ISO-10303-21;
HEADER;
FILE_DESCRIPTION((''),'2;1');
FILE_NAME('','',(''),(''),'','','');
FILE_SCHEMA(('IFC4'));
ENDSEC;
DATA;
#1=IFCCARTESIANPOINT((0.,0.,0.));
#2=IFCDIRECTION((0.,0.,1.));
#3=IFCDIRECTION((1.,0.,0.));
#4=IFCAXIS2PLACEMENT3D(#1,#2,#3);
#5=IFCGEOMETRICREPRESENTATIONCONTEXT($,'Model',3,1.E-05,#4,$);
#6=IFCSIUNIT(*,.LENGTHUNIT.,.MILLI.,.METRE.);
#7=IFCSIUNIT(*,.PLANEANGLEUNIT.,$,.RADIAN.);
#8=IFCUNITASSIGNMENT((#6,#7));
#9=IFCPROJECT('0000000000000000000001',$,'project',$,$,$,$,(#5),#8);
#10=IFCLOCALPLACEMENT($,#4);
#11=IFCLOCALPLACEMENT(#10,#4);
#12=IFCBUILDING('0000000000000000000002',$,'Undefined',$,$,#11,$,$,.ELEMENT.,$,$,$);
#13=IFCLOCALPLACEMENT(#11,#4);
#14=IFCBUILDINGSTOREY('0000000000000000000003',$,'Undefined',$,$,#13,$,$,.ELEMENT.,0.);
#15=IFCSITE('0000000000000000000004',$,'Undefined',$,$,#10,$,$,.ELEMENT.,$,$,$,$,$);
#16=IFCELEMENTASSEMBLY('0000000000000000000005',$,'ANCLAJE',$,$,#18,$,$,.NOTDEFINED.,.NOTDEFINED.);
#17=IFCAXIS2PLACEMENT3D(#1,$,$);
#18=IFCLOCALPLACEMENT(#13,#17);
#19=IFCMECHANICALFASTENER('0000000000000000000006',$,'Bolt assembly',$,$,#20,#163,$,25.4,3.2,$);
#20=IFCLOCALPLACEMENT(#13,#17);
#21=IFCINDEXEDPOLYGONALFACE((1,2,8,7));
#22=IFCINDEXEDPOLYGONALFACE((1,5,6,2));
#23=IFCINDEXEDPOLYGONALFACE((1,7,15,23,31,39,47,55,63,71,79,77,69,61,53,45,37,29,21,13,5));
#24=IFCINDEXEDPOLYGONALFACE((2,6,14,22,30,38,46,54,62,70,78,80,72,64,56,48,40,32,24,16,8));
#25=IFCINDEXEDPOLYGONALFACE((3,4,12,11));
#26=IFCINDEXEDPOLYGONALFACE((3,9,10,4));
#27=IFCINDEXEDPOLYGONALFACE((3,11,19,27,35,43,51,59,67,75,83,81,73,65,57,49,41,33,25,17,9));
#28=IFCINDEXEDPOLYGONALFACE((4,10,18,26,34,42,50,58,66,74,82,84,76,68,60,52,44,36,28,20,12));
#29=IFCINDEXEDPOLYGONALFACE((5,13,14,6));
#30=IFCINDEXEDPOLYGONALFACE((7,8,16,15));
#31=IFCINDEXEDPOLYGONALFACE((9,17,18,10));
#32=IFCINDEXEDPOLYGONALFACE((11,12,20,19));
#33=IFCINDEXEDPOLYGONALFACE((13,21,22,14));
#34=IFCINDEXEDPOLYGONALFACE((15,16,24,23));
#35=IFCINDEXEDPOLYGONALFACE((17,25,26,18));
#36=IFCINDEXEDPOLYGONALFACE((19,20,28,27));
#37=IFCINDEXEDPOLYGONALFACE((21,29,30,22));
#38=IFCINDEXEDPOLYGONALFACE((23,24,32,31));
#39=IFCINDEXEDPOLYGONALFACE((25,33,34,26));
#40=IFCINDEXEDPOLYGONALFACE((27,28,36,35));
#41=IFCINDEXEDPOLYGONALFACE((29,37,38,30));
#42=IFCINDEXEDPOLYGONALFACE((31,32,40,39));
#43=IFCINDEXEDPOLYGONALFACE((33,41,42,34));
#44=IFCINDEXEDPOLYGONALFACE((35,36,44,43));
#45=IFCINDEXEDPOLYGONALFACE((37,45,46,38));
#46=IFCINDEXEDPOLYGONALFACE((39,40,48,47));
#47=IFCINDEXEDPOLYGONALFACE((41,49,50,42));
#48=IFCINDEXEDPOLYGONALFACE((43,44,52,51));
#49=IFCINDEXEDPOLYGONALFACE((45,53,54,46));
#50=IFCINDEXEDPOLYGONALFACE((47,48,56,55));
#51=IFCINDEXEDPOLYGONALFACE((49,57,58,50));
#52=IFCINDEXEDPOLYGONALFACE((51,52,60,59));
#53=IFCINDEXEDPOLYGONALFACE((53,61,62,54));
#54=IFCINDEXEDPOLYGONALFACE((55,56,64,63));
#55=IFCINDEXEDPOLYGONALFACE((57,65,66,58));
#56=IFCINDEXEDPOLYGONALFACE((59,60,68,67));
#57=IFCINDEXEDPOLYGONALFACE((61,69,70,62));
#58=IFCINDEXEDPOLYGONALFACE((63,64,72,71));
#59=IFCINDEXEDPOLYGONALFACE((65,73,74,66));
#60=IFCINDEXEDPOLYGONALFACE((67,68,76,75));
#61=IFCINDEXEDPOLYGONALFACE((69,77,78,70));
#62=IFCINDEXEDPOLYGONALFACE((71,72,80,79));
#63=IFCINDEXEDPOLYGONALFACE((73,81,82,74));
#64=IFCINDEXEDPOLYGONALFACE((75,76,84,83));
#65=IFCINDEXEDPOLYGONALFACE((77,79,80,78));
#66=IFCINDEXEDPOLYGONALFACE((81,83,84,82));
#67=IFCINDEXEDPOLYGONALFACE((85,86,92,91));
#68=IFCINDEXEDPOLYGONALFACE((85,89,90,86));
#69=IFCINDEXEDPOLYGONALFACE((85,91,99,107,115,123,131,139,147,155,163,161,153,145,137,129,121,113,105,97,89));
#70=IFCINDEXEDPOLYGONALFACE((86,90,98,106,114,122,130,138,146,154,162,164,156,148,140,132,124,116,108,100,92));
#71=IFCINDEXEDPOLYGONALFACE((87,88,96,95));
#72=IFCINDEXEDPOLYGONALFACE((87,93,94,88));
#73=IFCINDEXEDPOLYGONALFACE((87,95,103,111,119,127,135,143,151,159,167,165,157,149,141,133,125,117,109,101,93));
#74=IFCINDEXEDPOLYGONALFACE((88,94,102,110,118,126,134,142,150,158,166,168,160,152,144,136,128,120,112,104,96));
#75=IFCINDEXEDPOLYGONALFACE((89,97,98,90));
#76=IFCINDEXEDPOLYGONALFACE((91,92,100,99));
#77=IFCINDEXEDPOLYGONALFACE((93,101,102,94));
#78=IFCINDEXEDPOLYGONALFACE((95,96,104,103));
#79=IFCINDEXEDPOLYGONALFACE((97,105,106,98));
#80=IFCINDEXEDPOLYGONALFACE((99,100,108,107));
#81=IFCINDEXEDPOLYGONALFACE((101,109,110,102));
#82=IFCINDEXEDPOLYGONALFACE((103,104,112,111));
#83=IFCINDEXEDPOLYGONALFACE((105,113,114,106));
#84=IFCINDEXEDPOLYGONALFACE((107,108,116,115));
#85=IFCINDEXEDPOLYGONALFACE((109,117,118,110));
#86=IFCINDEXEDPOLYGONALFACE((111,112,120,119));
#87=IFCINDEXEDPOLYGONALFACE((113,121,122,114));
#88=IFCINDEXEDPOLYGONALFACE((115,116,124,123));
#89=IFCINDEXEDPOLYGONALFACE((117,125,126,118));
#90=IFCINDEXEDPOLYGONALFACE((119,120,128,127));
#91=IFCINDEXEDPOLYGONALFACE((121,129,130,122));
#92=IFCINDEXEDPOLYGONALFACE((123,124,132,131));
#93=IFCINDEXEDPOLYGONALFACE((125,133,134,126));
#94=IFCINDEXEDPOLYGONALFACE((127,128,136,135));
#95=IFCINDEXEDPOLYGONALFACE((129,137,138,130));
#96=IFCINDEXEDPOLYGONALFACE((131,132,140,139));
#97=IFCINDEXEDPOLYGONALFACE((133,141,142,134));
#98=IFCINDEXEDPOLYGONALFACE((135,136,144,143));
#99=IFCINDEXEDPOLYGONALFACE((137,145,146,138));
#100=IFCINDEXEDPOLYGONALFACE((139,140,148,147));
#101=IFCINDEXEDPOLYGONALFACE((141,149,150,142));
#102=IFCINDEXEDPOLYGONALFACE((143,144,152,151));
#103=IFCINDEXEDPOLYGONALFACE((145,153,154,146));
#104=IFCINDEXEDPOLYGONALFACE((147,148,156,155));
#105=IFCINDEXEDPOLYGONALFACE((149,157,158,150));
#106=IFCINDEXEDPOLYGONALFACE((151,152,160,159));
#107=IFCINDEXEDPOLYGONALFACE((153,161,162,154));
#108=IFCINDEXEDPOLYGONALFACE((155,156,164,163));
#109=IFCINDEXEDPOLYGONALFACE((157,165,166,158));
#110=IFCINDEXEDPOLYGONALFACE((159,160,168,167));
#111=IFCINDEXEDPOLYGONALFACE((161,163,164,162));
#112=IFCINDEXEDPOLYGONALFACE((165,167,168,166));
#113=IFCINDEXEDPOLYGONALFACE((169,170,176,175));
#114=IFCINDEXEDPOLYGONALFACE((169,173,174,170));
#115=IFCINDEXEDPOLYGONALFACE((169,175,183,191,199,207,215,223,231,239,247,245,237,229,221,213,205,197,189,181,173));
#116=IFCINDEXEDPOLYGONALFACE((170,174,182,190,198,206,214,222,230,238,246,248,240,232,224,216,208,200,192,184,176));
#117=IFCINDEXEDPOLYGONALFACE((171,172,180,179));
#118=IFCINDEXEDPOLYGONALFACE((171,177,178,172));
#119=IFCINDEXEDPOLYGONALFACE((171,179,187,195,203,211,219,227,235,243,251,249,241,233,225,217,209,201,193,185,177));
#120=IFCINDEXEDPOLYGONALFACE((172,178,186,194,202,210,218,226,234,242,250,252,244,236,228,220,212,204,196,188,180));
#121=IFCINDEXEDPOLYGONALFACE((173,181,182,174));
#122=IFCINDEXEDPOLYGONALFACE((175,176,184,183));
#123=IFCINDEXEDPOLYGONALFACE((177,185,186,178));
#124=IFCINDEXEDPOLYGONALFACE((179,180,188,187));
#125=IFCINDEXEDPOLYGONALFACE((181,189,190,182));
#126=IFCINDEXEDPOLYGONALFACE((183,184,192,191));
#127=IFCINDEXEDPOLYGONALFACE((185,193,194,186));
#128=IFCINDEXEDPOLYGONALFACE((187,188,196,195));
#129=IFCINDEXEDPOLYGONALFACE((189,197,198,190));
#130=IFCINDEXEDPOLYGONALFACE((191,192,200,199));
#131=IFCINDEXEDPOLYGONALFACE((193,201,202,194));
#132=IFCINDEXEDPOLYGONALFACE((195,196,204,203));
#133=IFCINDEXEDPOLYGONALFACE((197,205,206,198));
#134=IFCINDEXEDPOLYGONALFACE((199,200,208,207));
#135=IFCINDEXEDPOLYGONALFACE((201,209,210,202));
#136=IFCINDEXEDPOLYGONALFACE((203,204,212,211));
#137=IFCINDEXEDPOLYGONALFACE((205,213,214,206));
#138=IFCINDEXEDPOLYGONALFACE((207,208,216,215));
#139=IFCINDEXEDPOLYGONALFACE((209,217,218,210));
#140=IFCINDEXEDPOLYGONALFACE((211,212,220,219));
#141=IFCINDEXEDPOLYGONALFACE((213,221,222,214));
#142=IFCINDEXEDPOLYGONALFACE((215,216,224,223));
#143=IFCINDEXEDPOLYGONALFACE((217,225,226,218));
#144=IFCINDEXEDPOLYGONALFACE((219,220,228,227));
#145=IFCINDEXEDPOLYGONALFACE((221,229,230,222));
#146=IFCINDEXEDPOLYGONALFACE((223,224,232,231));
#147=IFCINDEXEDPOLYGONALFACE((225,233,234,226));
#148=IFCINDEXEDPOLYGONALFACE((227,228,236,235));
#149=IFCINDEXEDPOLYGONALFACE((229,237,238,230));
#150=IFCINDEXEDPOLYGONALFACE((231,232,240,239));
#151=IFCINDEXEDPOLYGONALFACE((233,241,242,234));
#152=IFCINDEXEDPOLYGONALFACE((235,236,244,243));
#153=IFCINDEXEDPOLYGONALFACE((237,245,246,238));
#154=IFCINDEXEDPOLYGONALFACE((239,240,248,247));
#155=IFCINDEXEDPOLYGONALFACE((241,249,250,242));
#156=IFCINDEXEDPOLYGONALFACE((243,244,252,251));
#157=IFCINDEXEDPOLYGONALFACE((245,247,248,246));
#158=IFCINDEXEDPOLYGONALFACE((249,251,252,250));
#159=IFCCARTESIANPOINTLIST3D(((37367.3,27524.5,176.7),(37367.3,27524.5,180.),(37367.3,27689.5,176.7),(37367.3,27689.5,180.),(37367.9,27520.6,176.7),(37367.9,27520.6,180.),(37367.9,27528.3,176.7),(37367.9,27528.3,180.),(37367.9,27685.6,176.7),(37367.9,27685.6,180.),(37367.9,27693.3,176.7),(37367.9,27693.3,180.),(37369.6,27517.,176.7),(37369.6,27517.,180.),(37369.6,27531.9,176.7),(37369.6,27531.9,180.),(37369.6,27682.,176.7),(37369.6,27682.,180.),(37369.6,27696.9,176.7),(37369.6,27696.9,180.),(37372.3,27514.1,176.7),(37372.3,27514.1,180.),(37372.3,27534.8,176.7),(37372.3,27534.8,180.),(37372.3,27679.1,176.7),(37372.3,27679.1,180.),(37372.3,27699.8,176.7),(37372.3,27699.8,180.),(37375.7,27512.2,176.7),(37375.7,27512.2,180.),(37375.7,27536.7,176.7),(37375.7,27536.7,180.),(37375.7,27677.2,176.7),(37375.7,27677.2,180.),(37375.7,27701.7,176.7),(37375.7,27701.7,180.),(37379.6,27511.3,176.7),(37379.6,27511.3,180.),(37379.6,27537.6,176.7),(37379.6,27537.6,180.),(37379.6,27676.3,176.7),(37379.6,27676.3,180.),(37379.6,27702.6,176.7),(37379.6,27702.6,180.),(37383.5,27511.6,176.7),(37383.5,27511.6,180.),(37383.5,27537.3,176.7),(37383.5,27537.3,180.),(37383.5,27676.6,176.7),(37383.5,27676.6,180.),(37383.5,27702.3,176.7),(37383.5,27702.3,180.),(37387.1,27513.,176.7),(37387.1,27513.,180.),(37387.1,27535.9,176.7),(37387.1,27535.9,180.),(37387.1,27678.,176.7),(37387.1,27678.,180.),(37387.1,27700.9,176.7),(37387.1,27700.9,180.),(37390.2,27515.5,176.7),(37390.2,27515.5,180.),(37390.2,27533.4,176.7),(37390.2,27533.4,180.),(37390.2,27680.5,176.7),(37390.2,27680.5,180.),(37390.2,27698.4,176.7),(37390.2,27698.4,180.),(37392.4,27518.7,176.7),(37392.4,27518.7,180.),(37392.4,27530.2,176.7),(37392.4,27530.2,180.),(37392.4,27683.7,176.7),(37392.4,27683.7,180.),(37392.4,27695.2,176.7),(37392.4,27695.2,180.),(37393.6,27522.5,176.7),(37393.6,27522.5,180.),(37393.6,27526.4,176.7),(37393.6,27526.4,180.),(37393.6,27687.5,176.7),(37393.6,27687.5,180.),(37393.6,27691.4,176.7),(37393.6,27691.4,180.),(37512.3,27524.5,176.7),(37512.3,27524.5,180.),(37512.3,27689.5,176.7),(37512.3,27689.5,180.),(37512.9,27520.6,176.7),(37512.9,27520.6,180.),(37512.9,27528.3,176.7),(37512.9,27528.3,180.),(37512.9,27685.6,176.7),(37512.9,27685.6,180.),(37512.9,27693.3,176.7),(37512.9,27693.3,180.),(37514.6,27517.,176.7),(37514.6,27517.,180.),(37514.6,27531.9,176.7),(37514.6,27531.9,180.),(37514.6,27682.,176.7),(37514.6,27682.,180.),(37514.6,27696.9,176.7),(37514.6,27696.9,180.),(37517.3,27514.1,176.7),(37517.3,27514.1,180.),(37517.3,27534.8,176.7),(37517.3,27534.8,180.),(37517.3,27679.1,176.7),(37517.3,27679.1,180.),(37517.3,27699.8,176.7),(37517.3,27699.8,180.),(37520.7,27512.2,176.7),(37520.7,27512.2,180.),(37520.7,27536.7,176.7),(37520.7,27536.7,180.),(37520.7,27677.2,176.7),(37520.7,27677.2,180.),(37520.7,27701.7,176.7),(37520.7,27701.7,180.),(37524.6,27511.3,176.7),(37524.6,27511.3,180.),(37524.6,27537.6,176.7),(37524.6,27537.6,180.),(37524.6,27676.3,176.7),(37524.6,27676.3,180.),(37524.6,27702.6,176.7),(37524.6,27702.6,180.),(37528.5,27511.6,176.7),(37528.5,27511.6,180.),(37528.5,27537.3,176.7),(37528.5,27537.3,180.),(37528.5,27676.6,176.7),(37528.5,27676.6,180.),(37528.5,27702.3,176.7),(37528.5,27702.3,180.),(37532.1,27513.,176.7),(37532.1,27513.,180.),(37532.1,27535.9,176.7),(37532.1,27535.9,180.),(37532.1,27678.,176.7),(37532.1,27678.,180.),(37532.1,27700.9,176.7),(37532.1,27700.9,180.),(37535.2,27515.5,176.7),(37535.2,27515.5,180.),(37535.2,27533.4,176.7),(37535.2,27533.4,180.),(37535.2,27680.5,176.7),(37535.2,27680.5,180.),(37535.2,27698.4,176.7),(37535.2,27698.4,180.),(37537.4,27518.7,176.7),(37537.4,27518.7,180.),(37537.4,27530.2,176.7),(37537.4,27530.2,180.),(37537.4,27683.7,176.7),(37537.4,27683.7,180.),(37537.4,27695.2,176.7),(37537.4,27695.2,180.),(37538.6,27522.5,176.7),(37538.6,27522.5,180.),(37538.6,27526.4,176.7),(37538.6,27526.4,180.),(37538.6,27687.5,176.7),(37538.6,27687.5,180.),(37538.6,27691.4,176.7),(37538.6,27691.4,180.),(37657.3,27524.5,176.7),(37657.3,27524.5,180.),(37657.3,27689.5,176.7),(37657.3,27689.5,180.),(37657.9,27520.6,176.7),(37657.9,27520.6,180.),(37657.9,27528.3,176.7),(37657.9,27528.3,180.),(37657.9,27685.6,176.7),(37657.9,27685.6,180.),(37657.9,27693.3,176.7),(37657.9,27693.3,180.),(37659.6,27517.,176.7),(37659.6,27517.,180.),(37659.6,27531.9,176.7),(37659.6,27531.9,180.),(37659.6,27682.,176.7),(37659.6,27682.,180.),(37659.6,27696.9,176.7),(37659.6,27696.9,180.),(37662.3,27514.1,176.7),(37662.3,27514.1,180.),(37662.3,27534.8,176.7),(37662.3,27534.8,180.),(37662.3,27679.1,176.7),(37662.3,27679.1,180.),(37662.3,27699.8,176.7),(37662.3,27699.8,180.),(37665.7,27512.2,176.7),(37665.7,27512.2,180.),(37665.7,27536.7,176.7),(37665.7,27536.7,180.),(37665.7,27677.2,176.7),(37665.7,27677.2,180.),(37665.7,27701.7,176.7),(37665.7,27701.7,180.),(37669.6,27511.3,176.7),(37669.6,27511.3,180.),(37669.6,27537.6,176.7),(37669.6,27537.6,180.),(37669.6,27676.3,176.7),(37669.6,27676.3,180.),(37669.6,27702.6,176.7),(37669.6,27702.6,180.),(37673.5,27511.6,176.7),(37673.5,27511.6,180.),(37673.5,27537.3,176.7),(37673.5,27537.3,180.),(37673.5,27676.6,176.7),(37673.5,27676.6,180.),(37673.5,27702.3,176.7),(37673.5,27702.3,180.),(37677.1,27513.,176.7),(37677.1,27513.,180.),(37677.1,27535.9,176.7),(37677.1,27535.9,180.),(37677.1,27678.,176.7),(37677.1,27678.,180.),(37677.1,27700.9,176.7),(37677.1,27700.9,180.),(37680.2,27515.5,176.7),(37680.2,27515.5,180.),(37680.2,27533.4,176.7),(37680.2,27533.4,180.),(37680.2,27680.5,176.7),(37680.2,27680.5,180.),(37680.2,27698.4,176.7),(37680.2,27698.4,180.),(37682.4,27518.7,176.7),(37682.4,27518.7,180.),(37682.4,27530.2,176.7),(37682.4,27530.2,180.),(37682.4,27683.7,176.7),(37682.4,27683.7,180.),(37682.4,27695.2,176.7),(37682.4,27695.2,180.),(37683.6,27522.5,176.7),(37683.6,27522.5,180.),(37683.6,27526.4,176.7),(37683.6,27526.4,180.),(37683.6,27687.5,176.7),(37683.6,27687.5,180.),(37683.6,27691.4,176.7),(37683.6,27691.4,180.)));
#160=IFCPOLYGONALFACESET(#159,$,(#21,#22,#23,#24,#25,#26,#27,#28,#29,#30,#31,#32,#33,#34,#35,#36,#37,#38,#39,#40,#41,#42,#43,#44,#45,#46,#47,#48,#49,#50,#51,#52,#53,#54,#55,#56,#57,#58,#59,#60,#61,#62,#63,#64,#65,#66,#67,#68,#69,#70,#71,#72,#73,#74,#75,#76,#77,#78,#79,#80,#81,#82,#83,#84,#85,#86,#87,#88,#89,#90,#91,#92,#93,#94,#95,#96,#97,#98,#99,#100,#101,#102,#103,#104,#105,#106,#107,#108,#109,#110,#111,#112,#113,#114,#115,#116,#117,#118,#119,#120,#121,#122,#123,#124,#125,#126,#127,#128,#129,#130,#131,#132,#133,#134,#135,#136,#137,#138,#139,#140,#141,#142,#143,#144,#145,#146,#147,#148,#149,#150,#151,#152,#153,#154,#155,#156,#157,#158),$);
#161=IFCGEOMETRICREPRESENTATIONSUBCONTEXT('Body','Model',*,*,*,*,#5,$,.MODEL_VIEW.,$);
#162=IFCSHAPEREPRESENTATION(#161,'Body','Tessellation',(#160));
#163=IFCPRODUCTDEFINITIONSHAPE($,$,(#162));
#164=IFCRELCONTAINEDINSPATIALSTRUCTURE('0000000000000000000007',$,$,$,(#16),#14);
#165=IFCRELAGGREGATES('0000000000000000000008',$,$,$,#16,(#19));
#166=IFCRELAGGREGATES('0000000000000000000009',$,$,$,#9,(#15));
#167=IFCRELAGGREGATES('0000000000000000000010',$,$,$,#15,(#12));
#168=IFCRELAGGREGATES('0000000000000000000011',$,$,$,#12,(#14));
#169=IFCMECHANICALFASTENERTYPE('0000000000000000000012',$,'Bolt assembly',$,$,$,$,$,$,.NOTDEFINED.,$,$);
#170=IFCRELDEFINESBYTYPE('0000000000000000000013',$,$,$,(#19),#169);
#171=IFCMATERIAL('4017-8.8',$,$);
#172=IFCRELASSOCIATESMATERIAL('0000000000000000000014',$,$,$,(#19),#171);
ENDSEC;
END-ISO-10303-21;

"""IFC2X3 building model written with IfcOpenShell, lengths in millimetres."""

from ifc_helpers import new_model, si_unit, frame, origin_with_axes, origin_2d_with_axis, place, context, subcontext, project, spatial, circle, extrude, source, transform, mapped, material, type_object, element, aggregate, save


model = new_model("IFC2X3")

# Units and contexts
model_context = context("Model", 3, precision=1e-05, world=origin_with_axes())
body_context = subcontext(model_context, "Body", "Model", "MODEL_VIEW")
ifc_project = project(units=[si_unit("LENGTHUNIT", "METRE", prefix="MILLI"), si_unit("PLANEANGLEUNIT", "RADIAN")], contexts=[model_context])

# Site, building, storey
site_placement = place(None, origin_with_axes())
site = spatial("IfcSite", under=ifc_project, at=site_placement, Name="Undefined", CompositionType="ELEMENT")
building_placement = place(site_placement, origin_with_axes())
building = spatial("IfcBuilding", under=site, at=building_placement, Name="Undefined", CompositionType="ELEMENT")
storey_placement = place(building_placement, origin_with_axes())
storey = spatial("IfcBuildingStorey", under=building, at=storey_placement, Name="Undefined", CompositionType="ELEMENT", Elevation=0.0)

# Element assembly
assembly_1_placement = place(storey_placement, origin_with_axes())
assembly_1 = element("IfcElementAssembly", 1, at=assembly_1_placement, inside=storey, Name="ANCLAJE", AssemblyPlace="NOTDEFINED", PredefinedType="NOTDEFINED")

# Mechanical fastener
mechanical_fastener_type = type_object("IfcMechanicalFastenerType", Name="Bolt assembly")
ifc_material_1 = material(Name="4017-8.8")
shared_shape_1 = source(origin_with_axes(), body_context, "Body", "SweptSolid", [
    extrude(circle(Radius=13.2, at=origin_2d_with_axis()), frame((0.0, -25.7, 0.0), z_axis=(0.0, 1.0, 0.0), x_axis=(1.0, 0.0, 0.0)), (0.0, 0.0, 1.0), 3.3),
])
mechanical_fastener_1_placement = place(assembly_1_placement, frame((37670.5, 27607.0, 202.4), z_axis=(0.0, 1.0, 0.0), x_axis=(-1.0, 0.0, 0.0)))
mechanical_fastener_1 = element("IfcMechanicalFastener", 2, at=mechanical_fastener_1_placement, type_object=mechanical_fastener_type, material=ifc_material_1, Name="Bolt assembly", NominalDiameter=25.4, NominalLength=3.2, context=body_context, shape_type="MappedRepresentation", body=[
    mapped(shared_shape_1, transform((0.0, 0.0, -82.5))),
    mapped(shared_shape_1, transform((145.0, 0.0, -82.5))),
    mapped(shared_shape_1, transform((290.0, 0.0, -82.5))),
    mapped(shared_shape_1, transform((0.0, 0.0, 82.5))),
    mapped(shared_shape_1, transform((145.0, 0.0, 82.5))),
    mapped(shared_shape_1, transform((290.0, 0.0, 82.5))),
])
aggregate(assembly_1, [mechanical_fastener_1])

save(model, "model.ifc")
